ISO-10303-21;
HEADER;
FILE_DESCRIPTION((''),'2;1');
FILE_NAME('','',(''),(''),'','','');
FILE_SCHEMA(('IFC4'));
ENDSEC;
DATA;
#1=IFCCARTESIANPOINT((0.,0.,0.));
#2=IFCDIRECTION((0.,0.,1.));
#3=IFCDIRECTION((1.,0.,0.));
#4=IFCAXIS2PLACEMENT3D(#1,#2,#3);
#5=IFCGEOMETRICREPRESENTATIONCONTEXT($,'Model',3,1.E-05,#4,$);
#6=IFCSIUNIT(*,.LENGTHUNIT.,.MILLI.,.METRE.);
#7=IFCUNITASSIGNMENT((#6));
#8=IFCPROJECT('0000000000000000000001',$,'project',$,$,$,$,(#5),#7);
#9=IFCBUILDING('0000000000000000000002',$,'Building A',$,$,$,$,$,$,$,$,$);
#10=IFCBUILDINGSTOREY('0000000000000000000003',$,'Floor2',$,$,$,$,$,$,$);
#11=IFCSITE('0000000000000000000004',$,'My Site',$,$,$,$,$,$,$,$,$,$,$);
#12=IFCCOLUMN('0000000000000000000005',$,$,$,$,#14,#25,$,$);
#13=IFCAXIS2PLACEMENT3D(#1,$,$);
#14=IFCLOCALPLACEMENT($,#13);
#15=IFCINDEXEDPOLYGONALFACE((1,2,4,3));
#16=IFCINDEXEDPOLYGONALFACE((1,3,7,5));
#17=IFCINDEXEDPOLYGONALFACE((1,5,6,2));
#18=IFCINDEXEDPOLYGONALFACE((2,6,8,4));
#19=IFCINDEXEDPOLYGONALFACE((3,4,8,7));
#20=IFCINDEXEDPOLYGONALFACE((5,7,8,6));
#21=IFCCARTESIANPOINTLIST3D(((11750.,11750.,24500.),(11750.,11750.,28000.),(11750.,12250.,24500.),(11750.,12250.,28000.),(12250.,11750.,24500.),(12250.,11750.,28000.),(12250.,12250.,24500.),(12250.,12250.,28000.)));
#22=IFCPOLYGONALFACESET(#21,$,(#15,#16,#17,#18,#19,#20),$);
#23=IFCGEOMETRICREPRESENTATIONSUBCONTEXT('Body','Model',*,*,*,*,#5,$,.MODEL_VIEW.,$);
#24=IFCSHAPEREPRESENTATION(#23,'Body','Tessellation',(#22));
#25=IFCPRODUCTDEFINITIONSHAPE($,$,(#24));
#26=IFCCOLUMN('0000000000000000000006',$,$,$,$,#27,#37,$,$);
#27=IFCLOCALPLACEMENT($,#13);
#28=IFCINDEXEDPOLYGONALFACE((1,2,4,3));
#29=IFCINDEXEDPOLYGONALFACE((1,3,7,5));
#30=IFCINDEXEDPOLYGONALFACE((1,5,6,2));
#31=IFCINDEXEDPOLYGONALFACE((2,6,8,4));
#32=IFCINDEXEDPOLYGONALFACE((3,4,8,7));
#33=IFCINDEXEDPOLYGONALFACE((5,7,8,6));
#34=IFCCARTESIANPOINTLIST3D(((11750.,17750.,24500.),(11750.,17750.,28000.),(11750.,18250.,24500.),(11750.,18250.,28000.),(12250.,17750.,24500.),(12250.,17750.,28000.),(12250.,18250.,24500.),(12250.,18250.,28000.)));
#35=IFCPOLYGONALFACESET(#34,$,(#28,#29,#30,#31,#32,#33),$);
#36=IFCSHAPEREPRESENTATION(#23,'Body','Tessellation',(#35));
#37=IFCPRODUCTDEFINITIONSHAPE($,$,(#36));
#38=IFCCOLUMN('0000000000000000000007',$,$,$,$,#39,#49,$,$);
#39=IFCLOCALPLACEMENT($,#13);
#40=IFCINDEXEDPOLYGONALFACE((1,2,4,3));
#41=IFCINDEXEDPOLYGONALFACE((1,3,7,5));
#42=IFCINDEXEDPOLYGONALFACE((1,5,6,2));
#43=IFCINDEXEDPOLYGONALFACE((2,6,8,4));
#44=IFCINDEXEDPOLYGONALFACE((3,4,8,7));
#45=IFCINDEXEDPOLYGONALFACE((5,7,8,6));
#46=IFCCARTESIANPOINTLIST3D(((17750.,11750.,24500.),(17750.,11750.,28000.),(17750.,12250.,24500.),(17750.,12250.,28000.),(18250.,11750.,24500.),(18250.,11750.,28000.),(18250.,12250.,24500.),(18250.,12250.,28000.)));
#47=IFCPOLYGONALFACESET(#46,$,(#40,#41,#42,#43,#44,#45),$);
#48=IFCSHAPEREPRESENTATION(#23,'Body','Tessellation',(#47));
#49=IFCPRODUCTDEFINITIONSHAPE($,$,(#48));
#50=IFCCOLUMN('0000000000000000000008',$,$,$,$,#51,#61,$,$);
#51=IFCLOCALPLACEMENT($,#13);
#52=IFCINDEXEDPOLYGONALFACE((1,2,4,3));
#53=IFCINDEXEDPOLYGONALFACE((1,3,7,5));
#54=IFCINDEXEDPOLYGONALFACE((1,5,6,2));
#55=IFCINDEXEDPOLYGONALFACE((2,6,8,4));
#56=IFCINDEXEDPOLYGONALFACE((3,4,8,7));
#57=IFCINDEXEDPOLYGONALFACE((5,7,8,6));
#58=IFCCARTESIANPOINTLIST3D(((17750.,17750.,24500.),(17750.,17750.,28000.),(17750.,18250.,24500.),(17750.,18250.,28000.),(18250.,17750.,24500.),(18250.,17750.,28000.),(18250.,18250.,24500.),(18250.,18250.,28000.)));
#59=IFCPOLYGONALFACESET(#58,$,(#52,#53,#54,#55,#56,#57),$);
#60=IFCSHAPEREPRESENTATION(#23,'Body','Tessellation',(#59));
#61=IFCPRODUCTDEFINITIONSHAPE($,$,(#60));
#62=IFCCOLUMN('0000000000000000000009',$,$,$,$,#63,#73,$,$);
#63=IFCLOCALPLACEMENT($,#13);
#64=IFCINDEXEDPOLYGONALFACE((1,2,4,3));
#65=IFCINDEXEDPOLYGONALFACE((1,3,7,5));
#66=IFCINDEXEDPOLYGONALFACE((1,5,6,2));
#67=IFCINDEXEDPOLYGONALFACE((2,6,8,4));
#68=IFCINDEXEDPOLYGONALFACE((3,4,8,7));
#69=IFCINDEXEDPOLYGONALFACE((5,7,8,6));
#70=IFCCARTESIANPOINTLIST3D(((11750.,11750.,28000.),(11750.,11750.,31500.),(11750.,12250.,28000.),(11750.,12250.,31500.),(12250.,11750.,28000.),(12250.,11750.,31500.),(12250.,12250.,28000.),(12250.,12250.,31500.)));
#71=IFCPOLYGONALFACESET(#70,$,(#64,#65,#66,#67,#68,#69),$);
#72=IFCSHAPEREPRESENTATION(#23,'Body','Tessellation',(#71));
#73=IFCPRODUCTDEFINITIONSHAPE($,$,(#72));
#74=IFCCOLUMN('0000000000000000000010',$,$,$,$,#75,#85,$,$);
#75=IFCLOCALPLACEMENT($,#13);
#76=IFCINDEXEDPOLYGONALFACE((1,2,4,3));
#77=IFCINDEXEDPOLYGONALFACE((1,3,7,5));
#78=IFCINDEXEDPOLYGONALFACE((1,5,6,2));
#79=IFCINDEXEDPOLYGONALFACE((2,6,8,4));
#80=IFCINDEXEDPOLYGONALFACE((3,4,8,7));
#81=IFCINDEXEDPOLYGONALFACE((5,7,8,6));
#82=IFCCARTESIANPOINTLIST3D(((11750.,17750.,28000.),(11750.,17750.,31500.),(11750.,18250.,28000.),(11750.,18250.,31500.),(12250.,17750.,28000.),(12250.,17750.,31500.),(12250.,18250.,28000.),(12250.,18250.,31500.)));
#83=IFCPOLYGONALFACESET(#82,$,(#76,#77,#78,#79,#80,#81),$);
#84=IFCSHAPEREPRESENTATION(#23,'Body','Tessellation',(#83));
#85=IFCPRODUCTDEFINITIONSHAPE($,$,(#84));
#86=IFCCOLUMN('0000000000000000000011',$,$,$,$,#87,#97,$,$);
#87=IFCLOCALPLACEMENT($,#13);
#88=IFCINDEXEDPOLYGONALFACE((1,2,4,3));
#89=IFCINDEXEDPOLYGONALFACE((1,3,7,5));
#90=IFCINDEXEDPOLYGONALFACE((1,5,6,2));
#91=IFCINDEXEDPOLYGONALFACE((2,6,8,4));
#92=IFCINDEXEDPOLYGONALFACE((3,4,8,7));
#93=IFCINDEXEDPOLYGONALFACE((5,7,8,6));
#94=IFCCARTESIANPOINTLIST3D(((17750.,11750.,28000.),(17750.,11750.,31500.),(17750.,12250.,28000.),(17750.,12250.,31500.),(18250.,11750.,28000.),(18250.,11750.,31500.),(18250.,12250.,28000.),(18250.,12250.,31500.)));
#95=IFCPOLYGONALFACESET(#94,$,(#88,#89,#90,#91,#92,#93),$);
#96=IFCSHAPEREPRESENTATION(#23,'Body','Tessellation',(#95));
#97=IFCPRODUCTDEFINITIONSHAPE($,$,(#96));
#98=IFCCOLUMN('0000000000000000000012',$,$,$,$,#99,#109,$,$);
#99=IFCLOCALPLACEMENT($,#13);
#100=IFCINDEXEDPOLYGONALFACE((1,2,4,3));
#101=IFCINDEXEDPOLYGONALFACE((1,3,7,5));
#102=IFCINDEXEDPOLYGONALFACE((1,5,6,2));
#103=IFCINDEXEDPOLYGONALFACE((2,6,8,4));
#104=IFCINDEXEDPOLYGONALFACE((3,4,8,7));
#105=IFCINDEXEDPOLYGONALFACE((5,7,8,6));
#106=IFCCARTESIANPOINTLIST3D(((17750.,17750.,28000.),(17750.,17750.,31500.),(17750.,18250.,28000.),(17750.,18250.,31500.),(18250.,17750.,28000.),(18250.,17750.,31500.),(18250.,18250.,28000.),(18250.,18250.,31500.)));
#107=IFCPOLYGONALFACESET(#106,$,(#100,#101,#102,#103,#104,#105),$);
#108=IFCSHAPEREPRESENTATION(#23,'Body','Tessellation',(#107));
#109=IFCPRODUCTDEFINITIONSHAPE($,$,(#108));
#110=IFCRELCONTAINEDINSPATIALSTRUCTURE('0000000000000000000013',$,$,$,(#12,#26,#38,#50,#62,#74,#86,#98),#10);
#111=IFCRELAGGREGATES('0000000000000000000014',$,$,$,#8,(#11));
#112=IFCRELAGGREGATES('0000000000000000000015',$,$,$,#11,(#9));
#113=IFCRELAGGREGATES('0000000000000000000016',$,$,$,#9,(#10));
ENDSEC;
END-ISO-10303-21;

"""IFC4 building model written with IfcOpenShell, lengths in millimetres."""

from ifc_helpers import new_model, si_unit, frame, origin_with_axes, place, context, subcontext, project, spatial, line, indexed_curve, outline, extrude, element, save


model = new_model("IFC4")

# Units and contexts
model_context = context("Model", 3, precision=1e-05, world=origin_with_axes())
body_context = subcontext(model_context, "Body", "Model", "MODEL_VIEW")
ifc_project = project(units=[si_unit("LENGTHUNIT", "METRE", prefix="MILLI")], contexts=[model_context])

# Site, building, storey
site = spatial("IfcSite", under=ifc_project, Name="My Site")
building = spatial("IfcBuilding", under=site, Name="Building A")
storey = spatial("IfcBuildingStorey", under=building, Name="Floor2")

# Columns
for number, where, z_axis, x_axis in (
    (1, (12000.0, 12000.0, 24500.0), (0.0, 0.0, 1.0), (1.0, 0.0, 0.0)),
    (2, (12000.0, 18000.0, 24500.0), (0.0, 0.0, 1.0), (1.0, 0.0, 0.0)),
    (3, (18000.0, 12000.0, 24500.0), (0.0, 0.0, 1.0), (1.0, 0.0, 0.0)),
    (4, (18000.0, 18000.0, 24500.0), (0.0, 0.0, 1.0), (1.0, 0.0, 0.0)),
    (5, (12000.0, 12000.0, 28000.0), (0.0, 0.0, 1.0), (1.0, 0.0, 0.0)),
    (6, (12000.0, 18000.0, 28000.0), (0.0, 0.0, 1.0), (1.0, 0.0, 0.0)),
    (7, (18000.0, 12000.0, 28000.0), (0.0, 0.0, 1.0), (1.0, 0.0, 0.0)),
    (8, (18000.0, 18000.0, 28000.0), (0.0, 0.0, 1.0), (1.0, 0.0, 0.0)),
):
    element("IfcColumn", number, at=place(None, frame(where, z_axis=z_axis, x_axis=x_axis)), inside=storey, context=body_context, shape_type="SweptSolid", body=[
        extrude(outline(indexed_curve([(-250.0, -250.0), (250.0, -250.0), (250.0, 250.0), (-250.0, 250.0)], segments=[line(1, 2, 3, 4, 1)])), origin_with_axes(), (0.0, 0.0, 1.0), 3500.0),
    ])

save(model, "model.ifc")
